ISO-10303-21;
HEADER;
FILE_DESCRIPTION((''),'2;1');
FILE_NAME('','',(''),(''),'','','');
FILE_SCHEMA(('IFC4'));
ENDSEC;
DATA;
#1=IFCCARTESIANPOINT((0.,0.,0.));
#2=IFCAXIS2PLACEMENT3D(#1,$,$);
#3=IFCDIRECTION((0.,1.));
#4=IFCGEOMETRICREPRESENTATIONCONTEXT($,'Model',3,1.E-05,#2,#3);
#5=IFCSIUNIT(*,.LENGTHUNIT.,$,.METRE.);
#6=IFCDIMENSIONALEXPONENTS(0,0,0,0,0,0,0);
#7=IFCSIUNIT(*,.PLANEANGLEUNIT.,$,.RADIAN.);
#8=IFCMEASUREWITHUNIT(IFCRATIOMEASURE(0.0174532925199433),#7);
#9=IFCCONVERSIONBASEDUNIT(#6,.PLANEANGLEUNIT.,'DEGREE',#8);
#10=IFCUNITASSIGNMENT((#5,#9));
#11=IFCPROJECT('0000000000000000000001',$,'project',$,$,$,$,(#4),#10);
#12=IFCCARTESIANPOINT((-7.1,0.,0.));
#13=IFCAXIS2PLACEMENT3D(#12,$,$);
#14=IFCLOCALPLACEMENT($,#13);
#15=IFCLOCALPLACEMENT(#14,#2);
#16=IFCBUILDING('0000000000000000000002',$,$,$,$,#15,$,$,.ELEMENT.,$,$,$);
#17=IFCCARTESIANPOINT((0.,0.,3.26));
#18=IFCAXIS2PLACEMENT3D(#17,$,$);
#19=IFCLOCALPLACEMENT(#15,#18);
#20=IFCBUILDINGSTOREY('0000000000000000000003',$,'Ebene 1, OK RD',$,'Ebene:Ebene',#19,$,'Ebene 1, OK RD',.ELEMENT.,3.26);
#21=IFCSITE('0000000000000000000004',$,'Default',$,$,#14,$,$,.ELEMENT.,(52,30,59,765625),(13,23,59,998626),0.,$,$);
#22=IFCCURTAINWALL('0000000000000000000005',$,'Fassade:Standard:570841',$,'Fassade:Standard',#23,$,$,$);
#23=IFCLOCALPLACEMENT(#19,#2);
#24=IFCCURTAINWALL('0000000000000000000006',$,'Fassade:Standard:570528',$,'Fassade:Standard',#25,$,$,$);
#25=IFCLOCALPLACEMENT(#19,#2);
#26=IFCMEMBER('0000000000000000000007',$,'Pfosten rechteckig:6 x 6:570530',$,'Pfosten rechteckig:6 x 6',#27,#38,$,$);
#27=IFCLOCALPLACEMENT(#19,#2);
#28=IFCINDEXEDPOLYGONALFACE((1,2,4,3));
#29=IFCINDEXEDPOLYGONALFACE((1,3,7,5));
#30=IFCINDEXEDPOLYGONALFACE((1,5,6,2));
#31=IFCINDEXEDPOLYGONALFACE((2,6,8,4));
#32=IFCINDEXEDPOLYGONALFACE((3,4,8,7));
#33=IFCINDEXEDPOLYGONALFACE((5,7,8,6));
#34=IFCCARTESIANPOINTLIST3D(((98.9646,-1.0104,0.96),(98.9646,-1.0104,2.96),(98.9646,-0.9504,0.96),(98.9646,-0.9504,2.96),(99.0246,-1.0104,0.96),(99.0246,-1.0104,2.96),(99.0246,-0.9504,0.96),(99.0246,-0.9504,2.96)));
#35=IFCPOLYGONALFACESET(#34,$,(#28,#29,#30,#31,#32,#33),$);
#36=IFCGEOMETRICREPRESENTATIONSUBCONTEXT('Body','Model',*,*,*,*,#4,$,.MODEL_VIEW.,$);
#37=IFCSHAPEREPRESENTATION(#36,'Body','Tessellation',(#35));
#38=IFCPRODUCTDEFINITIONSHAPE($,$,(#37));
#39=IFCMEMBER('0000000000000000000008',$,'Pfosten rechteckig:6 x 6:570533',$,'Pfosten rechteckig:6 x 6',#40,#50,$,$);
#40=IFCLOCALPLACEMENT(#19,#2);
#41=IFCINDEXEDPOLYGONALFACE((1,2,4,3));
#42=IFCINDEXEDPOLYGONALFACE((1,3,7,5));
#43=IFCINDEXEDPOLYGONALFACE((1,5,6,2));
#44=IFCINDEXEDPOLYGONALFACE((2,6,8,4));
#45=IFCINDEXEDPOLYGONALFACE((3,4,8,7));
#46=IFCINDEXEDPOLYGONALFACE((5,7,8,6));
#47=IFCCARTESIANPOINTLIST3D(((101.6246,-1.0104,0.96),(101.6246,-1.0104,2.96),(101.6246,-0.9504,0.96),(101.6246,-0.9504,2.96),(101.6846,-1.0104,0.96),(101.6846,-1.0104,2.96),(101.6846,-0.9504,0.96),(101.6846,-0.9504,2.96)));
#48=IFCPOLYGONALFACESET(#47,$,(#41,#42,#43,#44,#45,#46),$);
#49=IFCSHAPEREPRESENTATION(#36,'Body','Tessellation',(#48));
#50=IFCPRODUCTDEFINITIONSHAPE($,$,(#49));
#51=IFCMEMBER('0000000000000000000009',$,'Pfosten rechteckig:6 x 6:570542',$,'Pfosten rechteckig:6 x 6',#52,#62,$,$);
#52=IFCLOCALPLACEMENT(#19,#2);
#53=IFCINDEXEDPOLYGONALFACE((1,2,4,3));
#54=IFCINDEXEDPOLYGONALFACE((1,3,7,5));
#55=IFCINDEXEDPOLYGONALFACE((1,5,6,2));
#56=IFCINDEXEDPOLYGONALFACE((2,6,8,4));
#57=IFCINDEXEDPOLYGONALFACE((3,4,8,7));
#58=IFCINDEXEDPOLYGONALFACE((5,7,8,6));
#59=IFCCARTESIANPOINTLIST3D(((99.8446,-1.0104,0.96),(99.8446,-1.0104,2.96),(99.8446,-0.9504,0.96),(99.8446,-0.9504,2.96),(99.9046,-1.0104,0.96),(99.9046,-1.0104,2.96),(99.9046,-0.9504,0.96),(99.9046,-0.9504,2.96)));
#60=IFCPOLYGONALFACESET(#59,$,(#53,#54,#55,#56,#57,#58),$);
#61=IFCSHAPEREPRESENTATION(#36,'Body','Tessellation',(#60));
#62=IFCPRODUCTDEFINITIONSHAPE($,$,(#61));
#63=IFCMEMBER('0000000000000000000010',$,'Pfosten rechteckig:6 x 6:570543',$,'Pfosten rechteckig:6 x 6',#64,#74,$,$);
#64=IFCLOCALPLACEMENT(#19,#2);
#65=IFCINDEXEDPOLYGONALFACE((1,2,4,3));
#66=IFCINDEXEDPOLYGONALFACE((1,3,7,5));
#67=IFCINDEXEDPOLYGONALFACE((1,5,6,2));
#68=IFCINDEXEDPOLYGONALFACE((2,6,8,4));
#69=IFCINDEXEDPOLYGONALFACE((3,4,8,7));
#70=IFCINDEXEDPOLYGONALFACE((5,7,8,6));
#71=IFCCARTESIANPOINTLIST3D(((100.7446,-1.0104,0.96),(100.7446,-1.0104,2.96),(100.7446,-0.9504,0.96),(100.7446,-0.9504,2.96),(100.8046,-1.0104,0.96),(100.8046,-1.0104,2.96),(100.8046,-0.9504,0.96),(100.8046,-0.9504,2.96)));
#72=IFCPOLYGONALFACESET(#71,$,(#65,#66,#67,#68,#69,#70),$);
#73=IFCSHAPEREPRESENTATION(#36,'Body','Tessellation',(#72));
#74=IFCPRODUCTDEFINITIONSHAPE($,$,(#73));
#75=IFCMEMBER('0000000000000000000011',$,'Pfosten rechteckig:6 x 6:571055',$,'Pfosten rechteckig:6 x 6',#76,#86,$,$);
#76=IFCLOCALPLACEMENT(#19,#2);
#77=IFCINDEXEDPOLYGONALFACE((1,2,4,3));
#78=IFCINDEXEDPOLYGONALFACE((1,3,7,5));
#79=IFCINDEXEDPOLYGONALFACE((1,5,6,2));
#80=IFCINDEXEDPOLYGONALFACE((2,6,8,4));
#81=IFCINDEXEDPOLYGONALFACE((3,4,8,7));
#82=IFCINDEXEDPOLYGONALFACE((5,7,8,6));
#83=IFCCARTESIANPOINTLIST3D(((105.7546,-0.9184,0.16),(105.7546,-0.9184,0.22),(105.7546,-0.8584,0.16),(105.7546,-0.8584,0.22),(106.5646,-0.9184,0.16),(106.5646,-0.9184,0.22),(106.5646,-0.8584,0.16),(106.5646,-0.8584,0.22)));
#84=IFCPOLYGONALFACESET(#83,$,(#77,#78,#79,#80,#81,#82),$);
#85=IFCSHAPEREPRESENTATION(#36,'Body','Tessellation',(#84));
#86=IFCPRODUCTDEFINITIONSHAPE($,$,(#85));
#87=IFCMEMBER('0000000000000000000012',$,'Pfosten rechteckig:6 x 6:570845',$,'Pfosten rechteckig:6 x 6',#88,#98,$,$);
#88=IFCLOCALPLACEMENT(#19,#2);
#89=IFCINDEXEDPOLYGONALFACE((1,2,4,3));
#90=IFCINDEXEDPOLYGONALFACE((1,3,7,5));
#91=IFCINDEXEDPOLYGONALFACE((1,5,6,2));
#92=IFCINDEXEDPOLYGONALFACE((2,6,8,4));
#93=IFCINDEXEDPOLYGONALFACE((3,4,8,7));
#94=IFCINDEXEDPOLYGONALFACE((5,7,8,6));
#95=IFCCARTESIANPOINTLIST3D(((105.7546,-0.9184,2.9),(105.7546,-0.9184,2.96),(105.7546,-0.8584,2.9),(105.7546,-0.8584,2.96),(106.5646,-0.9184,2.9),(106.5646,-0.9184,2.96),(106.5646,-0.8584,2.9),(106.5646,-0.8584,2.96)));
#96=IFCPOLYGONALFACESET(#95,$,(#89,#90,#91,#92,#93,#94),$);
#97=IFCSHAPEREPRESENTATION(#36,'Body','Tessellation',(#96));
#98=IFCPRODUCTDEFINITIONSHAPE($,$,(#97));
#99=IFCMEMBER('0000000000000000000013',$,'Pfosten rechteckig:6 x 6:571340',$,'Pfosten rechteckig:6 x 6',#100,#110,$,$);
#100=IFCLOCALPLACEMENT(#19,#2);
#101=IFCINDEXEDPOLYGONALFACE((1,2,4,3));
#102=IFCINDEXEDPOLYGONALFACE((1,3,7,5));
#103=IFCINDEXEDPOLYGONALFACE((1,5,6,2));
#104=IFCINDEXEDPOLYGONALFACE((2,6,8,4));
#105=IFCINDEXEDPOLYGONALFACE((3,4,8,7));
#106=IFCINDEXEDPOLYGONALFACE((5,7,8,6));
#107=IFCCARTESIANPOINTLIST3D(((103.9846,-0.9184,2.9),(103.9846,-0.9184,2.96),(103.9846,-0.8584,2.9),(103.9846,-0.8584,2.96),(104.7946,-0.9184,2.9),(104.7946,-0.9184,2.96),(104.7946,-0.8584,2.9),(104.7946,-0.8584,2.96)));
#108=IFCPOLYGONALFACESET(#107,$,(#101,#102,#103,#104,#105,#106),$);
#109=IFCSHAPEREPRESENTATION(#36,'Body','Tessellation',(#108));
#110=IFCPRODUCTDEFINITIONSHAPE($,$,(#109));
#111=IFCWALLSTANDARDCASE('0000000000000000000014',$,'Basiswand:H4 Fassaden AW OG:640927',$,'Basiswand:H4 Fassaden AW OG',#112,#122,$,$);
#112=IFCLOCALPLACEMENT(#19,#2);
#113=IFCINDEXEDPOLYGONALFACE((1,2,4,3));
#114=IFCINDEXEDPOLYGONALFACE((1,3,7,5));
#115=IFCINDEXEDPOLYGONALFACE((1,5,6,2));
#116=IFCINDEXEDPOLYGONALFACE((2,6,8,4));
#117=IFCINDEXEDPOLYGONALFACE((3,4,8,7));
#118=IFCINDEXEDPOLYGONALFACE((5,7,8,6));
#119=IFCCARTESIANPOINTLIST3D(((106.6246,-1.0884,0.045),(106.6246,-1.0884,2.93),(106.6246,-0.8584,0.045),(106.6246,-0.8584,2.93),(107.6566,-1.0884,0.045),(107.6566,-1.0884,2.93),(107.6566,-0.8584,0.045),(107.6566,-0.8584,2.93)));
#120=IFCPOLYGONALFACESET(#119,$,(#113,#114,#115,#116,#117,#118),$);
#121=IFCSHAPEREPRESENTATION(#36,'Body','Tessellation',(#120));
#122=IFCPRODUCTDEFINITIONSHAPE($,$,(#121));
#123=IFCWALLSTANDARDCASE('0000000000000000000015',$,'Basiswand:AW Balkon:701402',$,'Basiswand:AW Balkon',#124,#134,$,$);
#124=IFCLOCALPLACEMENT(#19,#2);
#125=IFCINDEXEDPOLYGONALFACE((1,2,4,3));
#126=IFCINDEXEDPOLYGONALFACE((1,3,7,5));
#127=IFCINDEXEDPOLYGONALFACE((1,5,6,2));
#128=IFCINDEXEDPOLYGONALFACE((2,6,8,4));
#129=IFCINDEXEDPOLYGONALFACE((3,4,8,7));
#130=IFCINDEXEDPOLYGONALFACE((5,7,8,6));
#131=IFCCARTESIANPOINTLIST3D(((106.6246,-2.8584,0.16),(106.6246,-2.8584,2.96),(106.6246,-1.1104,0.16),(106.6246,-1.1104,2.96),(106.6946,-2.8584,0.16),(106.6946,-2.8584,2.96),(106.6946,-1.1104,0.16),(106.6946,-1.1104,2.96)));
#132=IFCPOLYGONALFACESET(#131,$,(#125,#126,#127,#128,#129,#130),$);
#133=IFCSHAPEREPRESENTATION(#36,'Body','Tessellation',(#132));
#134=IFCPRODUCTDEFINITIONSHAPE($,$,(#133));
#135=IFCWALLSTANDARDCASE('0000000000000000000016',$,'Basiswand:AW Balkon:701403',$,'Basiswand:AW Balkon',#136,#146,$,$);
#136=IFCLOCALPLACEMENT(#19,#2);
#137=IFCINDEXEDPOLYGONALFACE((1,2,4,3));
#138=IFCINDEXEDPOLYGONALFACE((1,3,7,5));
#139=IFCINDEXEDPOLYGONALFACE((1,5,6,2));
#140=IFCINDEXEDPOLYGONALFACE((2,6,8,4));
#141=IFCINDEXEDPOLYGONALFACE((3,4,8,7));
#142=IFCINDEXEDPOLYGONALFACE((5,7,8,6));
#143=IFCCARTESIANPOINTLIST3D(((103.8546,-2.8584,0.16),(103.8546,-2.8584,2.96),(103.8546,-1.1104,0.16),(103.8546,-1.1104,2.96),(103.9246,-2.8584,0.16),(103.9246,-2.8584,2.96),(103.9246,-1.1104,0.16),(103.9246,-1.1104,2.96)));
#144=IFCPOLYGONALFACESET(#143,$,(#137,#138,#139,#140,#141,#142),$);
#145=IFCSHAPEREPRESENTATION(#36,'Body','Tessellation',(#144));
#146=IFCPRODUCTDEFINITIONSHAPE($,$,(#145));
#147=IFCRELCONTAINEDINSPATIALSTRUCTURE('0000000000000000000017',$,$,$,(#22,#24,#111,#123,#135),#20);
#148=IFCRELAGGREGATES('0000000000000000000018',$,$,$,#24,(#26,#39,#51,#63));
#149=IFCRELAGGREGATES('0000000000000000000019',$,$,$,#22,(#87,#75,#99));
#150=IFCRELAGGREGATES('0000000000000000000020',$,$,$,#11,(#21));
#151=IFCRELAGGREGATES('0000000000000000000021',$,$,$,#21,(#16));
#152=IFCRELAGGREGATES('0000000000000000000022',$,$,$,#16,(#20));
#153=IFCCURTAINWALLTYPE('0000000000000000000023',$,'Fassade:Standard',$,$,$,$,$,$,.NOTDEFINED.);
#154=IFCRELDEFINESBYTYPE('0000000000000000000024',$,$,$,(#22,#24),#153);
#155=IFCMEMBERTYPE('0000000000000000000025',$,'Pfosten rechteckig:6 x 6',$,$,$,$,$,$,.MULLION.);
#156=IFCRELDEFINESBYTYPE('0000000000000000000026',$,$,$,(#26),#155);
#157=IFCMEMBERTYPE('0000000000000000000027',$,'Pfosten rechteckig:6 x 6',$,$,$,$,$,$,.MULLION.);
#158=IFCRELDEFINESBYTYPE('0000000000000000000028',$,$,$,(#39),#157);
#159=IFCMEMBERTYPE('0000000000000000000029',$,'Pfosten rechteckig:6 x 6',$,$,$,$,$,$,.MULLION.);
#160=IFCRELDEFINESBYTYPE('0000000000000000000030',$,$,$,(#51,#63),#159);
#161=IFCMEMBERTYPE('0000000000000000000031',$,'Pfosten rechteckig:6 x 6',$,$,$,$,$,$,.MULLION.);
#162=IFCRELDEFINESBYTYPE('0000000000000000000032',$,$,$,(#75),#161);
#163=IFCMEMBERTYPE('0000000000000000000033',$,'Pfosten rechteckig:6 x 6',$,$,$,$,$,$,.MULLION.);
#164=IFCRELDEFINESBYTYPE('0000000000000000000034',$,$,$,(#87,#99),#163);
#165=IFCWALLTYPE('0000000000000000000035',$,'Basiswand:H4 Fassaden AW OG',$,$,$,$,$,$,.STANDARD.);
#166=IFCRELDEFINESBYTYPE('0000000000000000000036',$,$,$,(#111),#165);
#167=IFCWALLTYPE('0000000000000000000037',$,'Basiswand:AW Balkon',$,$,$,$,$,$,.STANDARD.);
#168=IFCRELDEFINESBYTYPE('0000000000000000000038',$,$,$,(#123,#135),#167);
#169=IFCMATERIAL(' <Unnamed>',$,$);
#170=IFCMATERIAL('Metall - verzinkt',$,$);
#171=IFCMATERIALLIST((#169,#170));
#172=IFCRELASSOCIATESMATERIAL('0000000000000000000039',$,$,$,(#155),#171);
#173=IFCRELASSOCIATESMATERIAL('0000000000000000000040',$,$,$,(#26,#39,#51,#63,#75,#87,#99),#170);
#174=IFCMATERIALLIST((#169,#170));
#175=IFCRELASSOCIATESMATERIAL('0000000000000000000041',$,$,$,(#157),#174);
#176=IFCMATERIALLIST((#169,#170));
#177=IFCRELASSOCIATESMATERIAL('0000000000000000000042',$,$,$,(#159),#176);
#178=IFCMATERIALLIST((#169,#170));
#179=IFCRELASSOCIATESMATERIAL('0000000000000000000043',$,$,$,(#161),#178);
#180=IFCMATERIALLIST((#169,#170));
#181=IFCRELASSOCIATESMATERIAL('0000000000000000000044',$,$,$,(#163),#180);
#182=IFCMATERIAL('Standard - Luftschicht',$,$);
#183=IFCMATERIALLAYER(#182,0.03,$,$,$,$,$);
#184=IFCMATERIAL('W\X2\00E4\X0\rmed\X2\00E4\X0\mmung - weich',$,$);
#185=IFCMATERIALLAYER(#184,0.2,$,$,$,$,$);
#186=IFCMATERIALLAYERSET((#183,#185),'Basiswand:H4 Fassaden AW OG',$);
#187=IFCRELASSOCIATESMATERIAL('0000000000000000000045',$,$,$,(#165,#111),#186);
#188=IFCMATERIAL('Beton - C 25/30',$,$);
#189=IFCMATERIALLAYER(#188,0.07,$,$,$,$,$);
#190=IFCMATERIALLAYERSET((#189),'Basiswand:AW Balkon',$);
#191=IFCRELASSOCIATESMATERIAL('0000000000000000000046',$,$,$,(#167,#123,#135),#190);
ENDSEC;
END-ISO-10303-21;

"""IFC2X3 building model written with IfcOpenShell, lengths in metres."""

from ifc_helpers import new_model, entity, si_unit, converted_unit, direction, frame, frame_2d, origin, origin_2d_with_axis, place, context, subcontext, project, spatial, rectangle, extrude, source, transform, mapped, material, material_list, layer, layer_set, layer_usage, type_object, type_shapes, element, aggregate, save


model = new_model("IFC2X3")

# Units and contexts
model_context = context("Model", 3, precision=1e-05, world=origin(), true_north=direction((0.0, 1.0)))
body_context = subcontext(model_context, "Body", "Model", "MODEL_VIEW")
ifc_project = project(units=[si_unit("LENGTHUNIT", "METRE"), converted_unit("PLANEANGLEUNIT", "DEGREE", entity("IfcRatioMeasure", 0.0174532925199433), si_unit("PLANEANGLEUNIT", "RADIAN"), dimensions=[0, 0, 0, 0, 0, 0, 0])], contexts=[model_context])

# Site, building, storey
site_placement = place(None, frame((-7.1, 0.0, 0.0)))
site = spatial("IfcSite", under=ifc_project, at=site_placement, Name="Default", CompositionType="ELEMENT", RefLatitude=(52, 30, 59, 765625), RefLongitude=(13, 23, 59, 998626), RefElevation=0.0)
building_placement = place(site_placement, origin())
building = spatial("IfcBuilding", under=site, at=building_placement, CompositionType="ELEMENT")
storey_placement = place(building_placement, frame((0.0, 0.0, 3.26)))
storey = spatial("IfcBuildingStorey", under=building, at=storey_placement, Name="Ebene 1, OK RD", ObjectType="Ebene:Ebene", LongName="Ebene 1, OK RD", CompositionType="ELEMENT", Elevation=3.26)

# Curtain wall
curtain_wall_type = type_object("IfcCurtainWallType", Name="Fassade:Standard", PredefinedType="NOTDEFINED")
curtain_wall_1_placement = place(storey_placement, frame((0.0, 0.0, -3.26)))
curtain_wall_1 = element("IfcCurtainWall", 1, at=curtain_wall_1_placement, inside=storey, type_object=curtain_wall_type, Name="Fassade:Standard:570841", ObjectType="Fassade:Standard")
ifc_material_1 = material(Name="Metall - verzinkt")
ifc_material_2 = material(Name=" <Unnamed>")

# Curtain wall
curtain_wall_2_placement = place(storey_placement, frame((0.0, 0.0, -3.26)))
curtain_wall_2 = element("IfcCurtainWall", 2, at=curtain_wall_2_placement, inside=storey, type_object=curtain_wall_type, Name="Fassade:Standard:570528", ObjectType="Fassade:Standard")

# Members
ifc_material_list_1 = material_list([ifc_material_2, ifc_material_1])
member_type_1 = type_object("IfcMemberType", Name="Pfosten rechteckig:6 x 6", PredefinedType="MULLION", material=ifc_material_list_1)
shared_shape_1 = source(origin(), body_context, "Body", "SweptSolid", [
    extrude(rectangle(XDim=0.06, YDim=0.06, at=origin_2d_with_axis()), frame((-0.03, 0.0, -2.0), z_axis=(0.0, 0.0, 1.0), x_axis=(0.0, -1.0, 0.0)), (0.0, 0.0, 1.0), 2.0),
])
type_shapes(member_type_1, [shared_shape_1])
member_1_placement = place(storey_placement, frame((98.9646, -0.9804, 2.96), z_axis=(0.0, 0.0, 1.0), x_axis=(-1.0, 0.0, 0.0)))
member_1 = element("IfcMember", 3, at=member_1_placement, type_object=member_type_1, material=ifc_material_1, Name="Pfosten rechteckig:6 x 6:570530", ObjectType="Pfosten rechteckig:6 x 6", context=body_context, shape_type="MappedRepresentation", body=[
    mapped(shared_shape_1, transform((0.0, 0.0, 0.0), scale=1.0)),
])
ifc_material_list_2 = material_list([ifc_material_2, ifc_material_1])
member_type_2 = type_object("IfcMemberType", Name="Pfosten rechteckig:6 x 6", PredefinedType="MULLION", material=ifc_material_list_2)
shared_shape_2 = source(origin(), body_context, "Body", "SweptSolid", [
    extrude(rectangle(XDim=0.06, YDim=0.06, at=origin_2d_with_axis()), frame((-0.03, 0.0, -2.0), z_axis=(0.0, 0.0, 1.0), x_axis=(0.0, -1.0, 0.0)), (0.0, 0.0, 1.0), 2.0),
])
type_shapes(member_type_2, [shared_shape_2])
member_2_placement = place(storey_placement, frame((101.6846, -0.9804, 0.96), z_axis=(0.0, 0.0, -1.0), x_axis=(1.0, 0.0, 0.0)))
member_2 = element("IfcMember", 4, at=member_2_placement, type_object=member_type_2, material=ifc_material_1, Name="Pfosten rechteckig:6 x 6:570533", ObjectType="Pfosten rechteckig:6 x 6", context=body_context, shape_type="MappedRepresentation", body=[
    mapped(shared_shape_2, transform((0.0, 0.0, 0.0), scale=1.0)),
])
ifc_material_list_3 = material_list([ifc_material_2, ifc_material_1])
member_type_3 = type_object("IfcMemberType", Name="Pfosten rechteckig:6 x 6", PredefinedType="MULLION", material=ifc_material_list_3)
shared_shape_3 = source(origin(), body_context, "Body", "SweptSolid", [
    extrude(rectangle(XDim=0.06, YDim=0.06, at=origin_2d_with_axis()), frame((0.0, 0.0, -2.0), z_axis=(0.0, 0.0, 1.0), x_axis=(0.0, -1.0, 0.0)), (0.0, 0.0, 1.0), 2.0),
])
type_shapes(member_type_3, [shared_shape_3])
member_3_placement = place(storey_placement, frame((99.8746, -0.9804, 0.96), z_axis=(0.0, 0.0, -1.0), x_axis=(1.0, 0.0, 0.0)))
member_3 = element("IfcMember", 5, at=member_3_placement, type_object=member_type_3, material=ifc_material_1, Name="Pfosten rechteckig:6 x 6:570542", ObjectType="Pfosten rechteckig:6 x 6", context=body_context, shape_type="MappedRepresentation", body=[
    mapped(shared_shape_3, transform((0.0, 0.0, 0.0), scale=1.0)),
])
member_4_placement = place(storey_placement, frame((100.7746, -0.9804, 0.96), z_axis=(0.0, 0.0, -1.0), x_axis=(1.0, 0.0, 0.0)))
member_4 = element("IfcMember", 6, at=member_4_placement, type_object=member_type_3, material=ifc_material_1, Name="Pfosten rechteckig:6 x 6:570543", ObjectType="Pfosten rechteckig:6 x 6", context=body_context, shape_type="MappedRepresentation", body=[
    mapped(shared_shape_3, transform((0.0, 0.0, 0.0), scale=1.0)),
])
ifc_material_list_4 = material_list([ifc_material_2, ifc_material_1])
member_type_4 = type_object("IfcMemberType", Name="Pfosten rechteckig:6 x 6", PredefinedType="MULLION", material=ifc_material_list_4)
shared_shape_4 = source(origin(), body_context, "Body", "SweptSolid", [
    extrude(rectangle(XDim=0.06, YDim=0.06, at=origin_2d_with_axis()), frame((-0.03, 0.0, -0.81), z_axis=(0.0, 0.0, 1.0), x_axis=(0.0, -1.0, 0.0)), (0.0, 0.0, 1.0), 0.81),
])
type_shapes(member_type_4, [shared_shape_4])
member_5_placement = place(storey_placement, frame((105.7546, -0.8884, 0.16), z_axis=(-1.0, 0.0, 0.0), x_axis=(0.0, 0.0, -1.0)))
member_5 = element("IfcMember", 7, at=member_5_placement, type_object=member_type_4, material=ifc_material_1, Name="Pfosten rechteckig:6 x 6:571055", ObjectType="Pfosten rechteckig:6 x 6", context=body_context, shape_type="MappedRepresentation", body=[
    mapped(shared_shape_4, transform((0.0, 0.0, 0.0), scale=1.0)),
])
ifc_material_list_5 = material_list([ifc_material_2, ifc_material_1])
member_type_5 = type_object("IfcMemberType", Name="Pfosten rechteckig:6 x 6", PredefinedType="MULLION", material=ifc_material_list_5)
shared_shape_5 = source(origin(), body_context, "Body", "SweptSolid", [
    extrude(rectangle(XDim=0.06, YDim=0.06, at=origin_2d_with_axis()), frame((-0.03, 0.0, -0.81), z_axis=(0.0, 0.0, 1.0), x_axis=(0.0, -1.0, 0.0)), (0.0, 0.0, 1.0), 0.81),
])
type_shapes(member_type_5, [shared_shape_5])
member_6_placement = place(storey_placement, frame((106.5646, -0.8884, 2.96), z_axis=(1.0, 0.0, 0.0), x_axis=(0.0, 0.0, 1.0)))
member_6 = element("IfcMember", 8, at=member_6_placement, type_object=member_type_5, material=ifc_material_1, Name="Pfosten rechteckig:6 x 6:570845", ObjectType="Pfosten rechteckig:6 x 6", context=body_context, shape_type="MappedRepresentation", body=[
    mapped(shared_shape_5, transform((0.0, 0.0, 0.0), scale=1.0)),
])
member_7_placement = place(storey_placement, frame((104.7946, -0.8884, 2.96), z_axis=(1.0, 0.0, 0.0), x_axis=(0.0, 0.0, 1.0)))
member_7 = element("IfcMember", 9, at=member_7_placement, type_object=member_type_5, material=ifc_material_1, Name="Pfosten rechteckig:6 x 6:571340", ObjectType="Pfosten rechteckig:6 x 6", context=body_context, shape_type="MappedRepresentation", body=[
    mapped(shared_shape_5, transform((0.0, 0.0, 0.0), scale=1.0)),
])

aggregate(curtain_wall_2, [member_1, member_2, member_3, member_4])
aggregate(curtain_wall_1, [member_6, member_5, member_7])

# Shared definitions
ifc_material_3 = material(Name="Standard - Luftschicht")
ifc_material_4 = material(Name="Wärmedämmung - weich")

# Wall
ifc_layer_1 = layer(ifc_material_3, 0.03)
ifc_layer_2 = layer(ifc_material_4, 0.2)
ifc_layer_set_1 = layer_set([ifc_layer_1, ifc_layer_2], Name="Basiswand:H4 Fassaden AW OG")
ifc_layer_usage_1 = layer_usage(ifc_layer_set_1, "AXIS2", "NEGATIVE", 0.115)
wall_type_1 = type_object("IfcWallType", Name="Basiswand:H4 Fassaden AW OG", PredefinedType="STANDARD", material=ifc_layer_set_1)
wall_1_placement = place(storey_placement, frame((107.6566, -0.9734, 0.045), z_axis=(0.0, 0.0, 1.0), x_axis=(-1.0, 0.0, 0.0)))
element("IfcWallStandardCase", 10, at=wall_1_placement, inside=storey, type_object=wall_type_1, material=ifc_layer_usage_1, Name="Basiswand:H4 Fassaden AW OG:640927", ObjectType="Basiswand:H4 Fassaden AW OG", context=body_context, shape_type="SweptSolid", body=[
    extrude(rectangle(XDim=1.032, YDim=0.23, at=frame_2d((0.516, 0.0), x_axis=(-1.0, 0.0))), origin(), (0.0, 0.0, 1.0), 2.885),
])

# Walls
ifc_material_5 = material(Name="Beton - C 25/30")
ifc_layer_3 = layer(ifc_material_5, 0.07)
ifc_layer_set_2 = layer_set([ifc_layer_3], Name="Basiswand:AW Balkon")
ifc_layer_usage_2 = layer_usage(ifc_layer_set_2, "AXIS2", "NEGATIVE", 0.035)
wall_type_2 = type_object("IfcWallType", Name="Basiswand:AW Balkon", PredefinedType="STANDARD", material=ifc_layer_set_2)
wall_2_placement = place(storey_placement, frame((106.6596, -1.1104, 0.16), z_axis=(0.0, 0.0, 1.0), x_axis=(0.0, -1.0, 0.0)))
element("IfcWallStandardCase", 11, at=wall_2_placement, inside=storey, type_object=wall_type_2, material=ifc_layer_usage_2, Name="Basiswand:AW Balkon:701402", ObjectType="Basiswand:AW Balkon", context=body_context, shape_type="SweptSolid", body=[
    extrude(rectangle(XDim=1.748, YDim=0.07, at=frame_2d((0.874, 0.0), x_axis=(-1.0, 0.0))), origin(), (0.0, 0.0, 1.0), 2.8),
])
ifc_layer_usage_3 = layer_usage(ifc_layer_set_2, "AXIS2", "NEGATIVE", 0.035)
wall_3_placement = place(storey_placement, frame((103.8896, -2.8584, 0.16), z_axis=(0.0, 0.0, 1.0), x_axis=(0.0, 1.0, 0.0)))
element("IfcWallStandardCase", 12, at=wall_3_placement, inside=storey, type_object=wall_type_2, material=ifc_layer_usage_3, Name="Basiswand:AW Balkon:701403", ObjectType="Basiswand:AW Balkon", context=body_context, shape_type="SweptSolid", body=[
    extrude(rectangle(XDim=1.748, YDim=0.07, at=frame_2d((0.874, 0.0), x_axis=(-1.0, 0.0))), origin(), (0.0, 0.0, 1.0), 2.8),
])

save(model, "model.ifc")
